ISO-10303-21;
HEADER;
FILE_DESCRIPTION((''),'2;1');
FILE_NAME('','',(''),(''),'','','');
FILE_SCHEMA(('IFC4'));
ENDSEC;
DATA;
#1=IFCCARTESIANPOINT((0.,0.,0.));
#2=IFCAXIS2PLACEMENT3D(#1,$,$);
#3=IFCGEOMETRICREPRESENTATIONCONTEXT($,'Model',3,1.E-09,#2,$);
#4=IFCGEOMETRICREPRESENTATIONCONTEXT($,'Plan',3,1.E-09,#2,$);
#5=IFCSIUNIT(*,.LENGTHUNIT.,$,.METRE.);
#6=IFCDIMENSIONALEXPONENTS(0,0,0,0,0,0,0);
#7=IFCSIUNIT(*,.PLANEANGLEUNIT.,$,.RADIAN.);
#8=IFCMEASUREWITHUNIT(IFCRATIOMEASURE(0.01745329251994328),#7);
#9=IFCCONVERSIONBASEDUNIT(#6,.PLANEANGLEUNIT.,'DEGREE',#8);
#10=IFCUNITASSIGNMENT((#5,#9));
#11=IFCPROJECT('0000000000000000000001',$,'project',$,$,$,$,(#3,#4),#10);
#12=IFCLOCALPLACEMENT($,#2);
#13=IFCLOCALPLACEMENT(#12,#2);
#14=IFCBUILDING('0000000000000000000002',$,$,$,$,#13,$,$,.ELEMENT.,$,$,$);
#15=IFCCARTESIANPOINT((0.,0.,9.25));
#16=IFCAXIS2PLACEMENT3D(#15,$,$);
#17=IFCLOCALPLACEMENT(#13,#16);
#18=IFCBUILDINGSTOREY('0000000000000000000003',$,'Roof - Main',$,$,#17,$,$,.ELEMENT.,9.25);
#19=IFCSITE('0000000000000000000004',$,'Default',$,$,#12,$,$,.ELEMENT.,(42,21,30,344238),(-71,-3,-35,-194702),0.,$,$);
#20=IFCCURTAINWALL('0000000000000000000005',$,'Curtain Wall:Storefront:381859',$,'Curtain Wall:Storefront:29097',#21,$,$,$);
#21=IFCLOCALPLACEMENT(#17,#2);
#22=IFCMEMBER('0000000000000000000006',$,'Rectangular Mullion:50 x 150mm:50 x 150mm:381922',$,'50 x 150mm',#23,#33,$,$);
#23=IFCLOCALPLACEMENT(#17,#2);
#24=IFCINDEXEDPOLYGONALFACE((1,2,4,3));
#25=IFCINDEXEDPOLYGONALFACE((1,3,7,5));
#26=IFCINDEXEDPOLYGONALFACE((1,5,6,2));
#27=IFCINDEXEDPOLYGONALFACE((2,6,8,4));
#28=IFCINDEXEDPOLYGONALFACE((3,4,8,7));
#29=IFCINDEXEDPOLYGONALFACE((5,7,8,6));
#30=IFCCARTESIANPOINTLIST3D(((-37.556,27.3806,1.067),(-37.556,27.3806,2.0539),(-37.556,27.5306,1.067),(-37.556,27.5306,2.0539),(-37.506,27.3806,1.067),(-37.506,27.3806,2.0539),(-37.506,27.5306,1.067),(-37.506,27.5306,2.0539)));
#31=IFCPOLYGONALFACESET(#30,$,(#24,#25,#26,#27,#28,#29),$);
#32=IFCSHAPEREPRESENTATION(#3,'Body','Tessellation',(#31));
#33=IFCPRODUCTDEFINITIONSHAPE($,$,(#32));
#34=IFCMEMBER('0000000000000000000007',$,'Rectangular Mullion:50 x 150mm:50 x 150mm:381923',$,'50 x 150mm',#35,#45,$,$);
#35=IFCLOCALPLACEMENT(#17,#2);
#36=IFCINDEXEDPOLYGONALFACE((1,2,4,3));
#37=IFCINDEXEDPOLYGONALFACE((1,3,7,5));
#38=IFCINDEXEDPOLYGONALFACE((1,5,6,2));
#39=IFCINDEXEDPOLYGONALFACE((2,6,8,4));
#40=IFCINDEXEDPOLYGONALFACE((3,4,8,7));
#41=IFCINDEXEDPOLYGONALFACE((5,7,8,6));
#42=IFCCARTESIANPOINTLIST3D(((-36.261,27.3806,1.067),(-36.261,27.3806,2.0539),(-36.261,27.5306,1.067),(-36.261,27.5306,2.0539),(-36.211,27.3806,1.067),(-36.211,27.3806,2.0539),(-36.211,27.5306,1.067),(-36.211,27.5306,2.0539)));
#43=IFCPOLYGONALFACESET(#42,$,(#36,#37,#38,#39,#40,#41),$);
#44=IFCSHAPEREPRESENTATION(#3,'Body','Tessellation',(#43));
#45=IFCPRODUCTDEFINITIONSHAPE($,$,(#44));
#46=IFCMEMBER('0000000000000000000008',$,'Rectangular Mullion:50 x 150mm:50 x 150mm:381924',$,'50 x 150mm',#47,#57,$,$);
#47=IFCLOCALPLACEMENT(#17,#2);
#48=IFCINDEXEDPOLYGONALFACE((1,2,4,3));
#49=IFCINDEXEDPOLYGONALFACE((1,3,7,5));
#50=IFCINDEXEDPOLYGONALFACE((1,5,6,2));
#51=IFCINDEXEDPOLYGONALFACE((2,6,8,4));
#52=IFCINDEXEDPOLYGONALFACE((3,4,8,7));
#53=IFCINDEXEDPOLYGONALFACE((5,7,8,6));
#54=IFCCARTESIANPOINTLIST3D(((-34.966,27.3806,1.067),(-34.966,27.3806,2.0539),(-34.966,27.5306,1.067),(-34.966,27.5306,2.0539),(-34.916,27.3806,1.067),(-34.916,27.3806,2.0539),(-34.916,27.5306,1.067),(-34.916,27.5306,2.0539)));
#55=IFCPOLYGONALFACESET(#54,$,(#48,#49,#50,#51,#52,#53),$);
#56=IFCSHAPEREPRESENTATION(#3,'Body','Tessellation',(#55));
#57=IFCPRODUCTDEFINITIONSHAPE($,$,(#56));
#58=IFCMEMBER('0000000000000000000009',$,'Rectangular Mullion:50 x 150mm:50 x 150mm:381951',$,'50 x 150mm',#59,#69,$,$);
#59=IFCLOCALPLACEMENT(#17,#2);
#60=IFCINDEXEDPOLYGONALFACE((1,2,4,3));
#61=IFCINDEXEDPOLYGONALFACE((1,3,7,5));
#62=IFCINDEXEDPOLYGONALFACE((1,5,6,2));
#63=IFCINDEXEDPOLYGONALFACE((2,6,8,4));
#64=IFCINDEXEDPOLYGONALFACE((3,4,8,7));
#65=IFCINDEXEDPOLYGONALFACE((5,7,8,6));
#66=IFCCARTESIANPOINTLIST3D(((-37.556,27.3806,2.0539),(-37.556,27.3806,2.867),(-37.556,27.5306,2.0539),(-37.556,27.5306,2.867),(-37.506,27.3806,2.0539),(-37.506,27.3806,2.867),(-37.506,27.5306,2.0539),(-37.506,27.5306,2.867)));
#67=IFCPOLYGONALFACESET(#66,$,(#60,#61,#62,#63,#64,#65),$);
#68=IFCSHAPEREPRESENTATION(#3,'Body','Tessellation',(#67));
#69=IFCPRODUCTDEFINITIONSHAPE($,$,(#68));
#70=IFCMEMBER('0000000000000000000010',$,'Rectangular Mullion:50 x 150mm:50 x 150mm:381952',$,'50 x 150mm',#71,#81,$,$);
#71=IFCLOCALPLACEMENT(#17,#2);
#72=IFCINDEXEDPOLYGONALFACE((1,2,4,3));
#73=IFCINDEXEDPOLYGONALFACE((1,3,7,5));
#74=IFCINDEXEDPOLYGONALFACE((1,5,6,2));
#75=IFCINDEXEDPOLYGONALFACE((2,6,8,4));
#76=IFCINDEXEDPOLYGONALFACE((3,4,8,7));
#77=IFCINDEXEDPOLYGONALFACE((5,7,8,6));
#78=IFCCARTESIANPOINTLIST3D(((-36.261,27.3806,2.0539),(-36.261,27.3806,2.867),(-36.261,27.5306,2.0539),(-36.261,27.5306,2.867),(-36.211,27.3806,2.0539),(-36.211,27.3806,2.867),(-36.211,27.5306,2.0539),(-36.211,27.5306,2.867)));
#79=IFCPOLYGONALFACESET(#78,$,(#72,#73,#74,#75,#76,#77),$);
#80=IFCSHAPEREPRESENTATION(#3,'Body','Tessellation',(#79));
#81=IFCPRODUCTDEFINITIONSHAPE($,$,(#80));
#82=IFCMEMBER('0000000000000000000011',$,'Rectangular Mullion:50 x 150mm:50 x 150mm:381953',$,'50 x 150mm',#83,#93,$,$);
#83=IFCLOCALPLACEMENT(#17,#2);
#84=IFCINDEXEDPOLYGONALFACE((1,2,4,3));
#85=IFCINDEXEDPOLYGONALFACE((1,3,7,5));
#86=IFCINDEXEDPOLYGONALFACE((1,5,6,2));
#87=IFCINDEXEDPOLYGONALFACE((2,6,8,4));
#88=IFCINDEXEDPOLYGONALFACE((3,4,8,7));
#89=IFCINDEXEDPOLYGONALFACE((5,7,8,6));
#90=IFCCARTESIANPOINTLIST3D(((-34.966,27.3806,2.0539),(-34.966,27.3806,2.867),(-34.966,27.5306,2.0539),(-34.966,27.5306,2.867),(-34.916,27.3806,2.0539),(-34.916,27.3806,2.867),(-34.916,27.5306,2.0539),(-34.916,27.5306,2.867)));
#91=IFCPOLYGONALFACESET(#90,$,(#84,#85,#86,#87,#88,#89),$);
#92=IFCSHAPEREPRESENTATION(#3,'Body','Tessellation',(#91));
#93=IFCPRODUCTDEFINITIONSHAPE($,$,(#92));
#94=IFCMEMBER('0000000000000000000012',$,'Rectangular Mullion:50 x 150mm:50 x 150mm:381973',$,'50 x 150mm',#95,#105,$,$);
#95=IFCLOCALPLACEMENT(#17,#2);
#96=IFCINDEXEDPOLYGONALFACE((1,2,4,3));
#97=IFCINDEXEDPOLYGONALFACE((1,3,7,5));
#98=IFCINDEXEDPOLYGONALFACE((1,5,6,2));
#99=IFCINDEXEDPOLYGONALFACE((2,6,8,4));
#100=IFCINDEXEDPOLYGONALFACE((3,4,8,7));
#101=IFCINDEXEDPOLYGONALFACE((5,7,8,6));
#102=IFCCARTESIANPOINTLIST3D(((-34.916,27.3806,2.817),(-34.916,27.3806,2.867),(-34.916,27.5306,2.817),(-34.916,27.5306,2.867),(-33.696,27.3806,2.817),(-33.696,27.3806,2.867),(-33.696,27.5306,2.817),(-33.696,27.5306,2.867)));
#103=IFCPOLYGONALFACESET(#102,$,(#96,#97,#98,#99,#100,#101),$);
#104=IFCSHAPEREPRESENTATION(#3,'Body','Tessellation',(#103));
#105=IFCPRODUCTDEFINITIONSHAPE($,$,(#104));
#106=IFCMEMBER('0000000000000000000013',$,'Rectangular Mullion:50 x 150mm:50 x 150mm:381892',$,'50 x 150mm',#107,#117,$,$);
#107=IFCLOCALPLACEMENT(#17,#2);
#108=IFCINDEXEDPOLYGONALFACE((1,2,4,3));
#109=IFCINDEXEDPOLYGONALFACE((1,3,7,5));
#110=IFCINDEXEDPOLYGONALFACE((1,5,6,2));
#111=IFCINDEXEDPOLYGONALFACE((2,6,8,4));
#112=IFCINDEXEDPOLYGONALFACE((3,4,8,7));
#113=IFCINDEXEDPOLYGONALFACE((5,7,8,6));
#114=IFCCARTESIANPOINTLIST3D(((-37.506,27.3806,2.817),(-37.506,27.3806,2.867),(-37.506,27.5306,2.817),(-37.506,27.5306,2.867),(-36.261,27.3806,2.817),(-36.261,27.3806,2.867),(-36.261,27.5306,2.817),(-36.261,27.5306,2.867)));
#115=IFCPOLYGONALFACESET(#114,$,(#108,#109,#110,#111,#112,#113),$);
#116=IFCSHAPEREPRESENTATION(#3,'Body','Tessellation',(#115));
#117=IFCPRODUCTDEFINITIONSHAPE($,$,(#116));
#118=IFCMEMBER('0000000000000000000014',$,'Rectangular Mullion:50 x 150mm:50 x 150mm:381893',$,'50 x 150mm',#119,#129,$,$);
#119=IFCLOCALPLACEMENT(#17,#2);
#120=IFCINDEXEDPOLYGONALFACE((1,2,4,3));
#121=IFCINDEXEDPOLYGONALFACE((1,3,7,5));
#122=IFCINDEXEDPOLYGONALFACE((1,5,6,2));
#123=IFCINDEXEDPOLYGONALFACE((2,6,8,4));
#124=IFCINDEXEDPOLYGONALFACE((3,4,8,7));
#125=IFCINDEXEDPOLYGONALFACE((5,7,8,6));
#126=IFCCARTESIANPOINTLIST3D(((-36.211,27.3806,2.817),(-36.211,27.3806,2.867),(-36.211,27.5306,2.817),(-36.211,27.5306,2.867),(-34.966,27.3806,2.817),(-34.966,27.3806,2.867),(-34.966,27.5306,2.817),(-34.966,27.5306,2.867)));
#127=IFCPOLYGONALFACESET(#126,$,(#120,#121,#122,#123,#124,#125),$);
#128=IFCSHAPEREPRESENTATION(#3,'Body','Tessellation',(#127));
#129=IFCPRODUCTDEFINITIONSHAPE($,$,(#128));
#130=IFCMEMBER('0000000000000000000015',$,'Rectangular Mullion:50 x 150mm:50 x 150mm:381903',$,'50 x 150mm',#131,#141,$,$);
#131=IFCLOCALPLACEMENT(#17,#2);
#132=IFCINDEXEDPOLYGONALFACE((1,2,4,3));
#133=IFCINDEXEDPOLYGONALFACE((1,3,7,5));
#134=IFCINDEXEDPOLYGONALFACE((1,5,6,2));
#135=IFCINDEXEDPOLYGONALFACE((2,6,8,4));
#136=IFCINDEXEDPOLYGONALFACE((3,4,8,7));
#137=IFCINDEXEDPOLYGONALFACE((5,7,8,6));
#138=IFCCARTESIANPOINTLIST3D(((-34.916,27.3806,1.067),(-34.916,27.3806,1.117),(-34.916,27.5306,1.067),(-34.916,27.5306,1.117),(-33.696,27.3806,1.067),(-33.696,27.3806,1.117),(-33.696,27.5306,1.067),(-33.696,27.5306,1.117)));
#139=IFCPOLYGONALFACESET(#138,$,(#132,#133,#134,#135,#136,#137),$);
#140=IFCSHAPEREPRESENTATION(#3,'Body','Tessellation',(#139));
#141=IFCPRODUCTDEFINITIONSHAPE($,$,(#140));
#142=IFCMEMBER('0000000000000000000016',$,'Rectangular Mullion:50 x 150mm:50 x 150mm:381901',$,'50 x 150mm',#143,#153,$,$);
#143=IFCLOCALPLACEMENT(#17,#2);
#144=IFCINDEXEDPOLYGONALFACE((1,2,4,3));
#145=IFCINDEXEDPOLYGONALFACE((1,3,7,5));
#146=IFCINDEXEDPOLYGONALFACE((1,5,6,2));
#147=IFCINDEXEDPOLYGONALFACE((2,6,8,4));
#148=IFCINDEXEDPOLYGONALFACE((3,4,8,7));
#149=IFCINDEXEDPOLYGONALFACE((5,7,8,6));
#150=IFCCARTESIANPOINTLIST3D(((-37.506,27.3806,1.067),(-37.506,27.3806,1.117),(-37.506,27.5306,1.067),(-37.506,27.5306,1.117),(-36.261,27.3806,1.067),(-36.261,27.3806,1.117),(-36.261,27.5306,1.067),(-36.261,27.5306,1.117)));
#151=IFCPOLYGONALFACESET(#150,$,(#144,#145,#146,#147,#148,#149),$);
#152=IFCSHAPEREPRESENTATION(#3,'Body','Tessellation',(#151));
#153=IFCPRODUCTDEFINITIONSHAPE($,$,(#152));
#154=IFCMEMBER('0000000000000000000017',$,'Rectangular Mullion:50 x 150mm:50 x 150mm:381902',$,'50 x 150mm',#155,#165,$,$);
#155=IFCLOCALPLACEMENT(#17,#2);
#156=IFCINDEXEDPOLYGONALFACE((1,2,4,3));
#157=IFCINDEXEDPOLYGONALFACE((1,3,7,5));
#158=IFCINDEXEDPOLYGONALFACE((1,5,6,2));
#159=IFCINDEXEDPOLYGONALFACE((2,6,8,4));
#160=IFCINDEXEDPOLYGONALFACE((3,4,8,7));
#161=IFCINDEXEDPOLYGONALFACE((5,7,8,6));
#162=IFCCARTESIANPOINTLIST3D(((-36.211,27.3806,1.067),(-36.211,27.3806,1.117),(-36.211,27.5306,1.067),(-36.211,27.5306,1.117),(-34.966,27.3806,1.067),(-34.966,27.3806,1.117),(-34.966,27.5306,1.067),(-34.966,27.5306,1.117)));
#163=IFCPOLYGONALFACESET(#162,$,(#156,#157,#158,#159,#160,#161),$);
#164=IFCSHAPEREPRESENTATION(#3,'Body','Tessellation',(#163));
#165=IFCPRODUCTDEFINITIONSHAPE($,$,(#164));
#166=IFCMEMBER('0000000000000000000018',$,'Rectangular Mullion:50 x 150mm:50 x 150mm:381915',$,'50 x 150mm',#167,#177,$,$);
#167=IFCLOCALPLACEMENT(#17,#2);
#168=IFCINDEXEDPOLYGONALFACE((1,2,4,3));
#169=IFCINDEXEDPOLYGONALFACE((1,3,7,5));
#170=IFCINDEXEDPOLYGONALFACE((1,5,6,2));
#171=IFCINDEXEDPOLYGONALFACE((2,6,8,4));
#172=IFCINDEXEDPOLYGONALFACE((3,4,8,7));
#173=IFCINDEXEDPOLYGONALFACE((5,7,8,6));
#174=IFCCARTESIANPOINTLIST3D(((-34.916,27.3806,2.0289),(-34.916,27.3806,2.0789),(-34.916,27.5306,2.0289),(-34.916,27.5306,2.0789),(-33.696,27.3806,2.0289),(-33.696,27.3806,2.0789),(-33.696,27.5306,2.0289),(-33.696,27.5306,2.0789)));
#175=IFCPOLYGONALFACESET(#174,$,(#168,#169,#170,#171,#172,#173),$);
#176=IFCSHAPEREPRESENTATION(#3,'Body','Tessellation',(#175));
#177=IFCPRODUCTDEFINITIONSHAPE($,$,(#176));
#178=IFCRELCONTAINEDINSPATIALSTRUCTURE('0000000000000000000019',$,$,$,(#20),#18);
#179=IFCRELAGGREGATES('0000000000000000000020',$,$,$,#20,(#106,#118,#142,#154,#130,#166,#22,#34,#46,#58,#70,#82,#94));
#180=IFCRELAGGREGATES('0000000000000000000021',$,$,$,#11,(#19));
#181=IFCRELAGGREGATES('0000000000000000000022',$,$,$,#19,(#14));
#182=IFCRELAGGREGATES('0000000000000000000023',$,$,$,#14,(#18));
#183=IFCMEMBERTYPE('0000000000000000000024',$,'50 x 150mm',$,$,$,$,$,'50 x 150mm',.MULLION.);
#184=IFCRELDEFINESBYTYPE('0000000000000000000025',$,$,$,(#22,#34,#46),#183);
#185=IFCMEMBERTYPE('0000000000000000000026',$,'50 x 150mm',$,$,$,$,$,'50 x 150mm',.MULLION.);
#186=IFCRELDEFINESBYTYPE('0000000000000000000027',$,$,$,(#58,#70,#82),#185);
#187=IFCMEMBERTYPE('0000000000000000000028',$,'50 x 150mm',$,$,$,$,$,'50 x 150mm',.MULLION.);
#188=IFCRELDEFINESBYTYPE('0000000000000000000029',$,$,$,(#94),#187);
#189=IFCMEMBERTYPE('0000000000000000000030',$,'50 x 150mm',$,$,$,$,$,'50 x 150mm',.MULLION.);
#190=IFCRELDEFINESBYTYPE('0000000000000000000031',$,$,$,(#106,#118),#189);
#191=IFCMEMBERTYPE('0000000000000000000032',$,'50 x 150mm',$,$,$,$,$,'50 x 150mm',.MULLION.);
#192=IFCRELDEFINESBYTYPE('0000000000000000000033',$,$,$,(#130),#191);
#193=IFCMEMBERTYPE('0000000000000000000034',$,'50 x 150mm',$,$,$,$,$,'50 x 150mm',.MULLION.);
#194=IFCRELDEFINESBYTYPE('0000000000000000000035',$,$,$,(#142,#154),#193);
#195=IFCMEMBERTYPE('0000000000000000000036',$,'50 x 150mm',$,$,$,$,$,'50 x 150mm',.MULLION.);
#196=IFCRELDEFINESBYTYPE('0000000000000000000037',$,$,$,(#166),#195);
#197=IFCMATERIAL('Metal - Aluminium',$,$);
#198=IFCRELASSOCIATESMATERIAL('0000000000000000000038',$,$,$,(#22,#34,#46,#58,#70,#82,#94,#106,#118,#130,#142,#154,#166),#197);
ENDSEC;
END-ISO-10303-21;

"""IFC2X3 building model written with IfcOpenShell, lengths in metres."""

from ifc_helpers import new_model, entity, si_unit, converted_unit, frame, origin, origin_2d_with_axis, place, context, project, spatial, rectangle, extrude, source, transform, mapped, material, type_object, type_shapes, element, aggregate, save


model = new_model("IFC2X3")

# Units and contexts
model_context = context("Model", 3, precision=1e-09, world=origin())
plan_context = context("Plan", 3, precision=1e-09, world=origin())
ifc_project = project(units=[si_unit("LENGTHUNIT", "METRE"), converted_unit("PLANEANGLEUNIT", "DEGREE", entity("IfcRatioMeasure", 0.01745329251994328), si_unit("PLANEANGLEUNIT", "RADIAN"), dimensions=[0, 0, 0, 0, 0, 0, 0])], contexts=[model_context, plan_context])

# Site, building, storey
site_placement = place(None, origin())
site = spatial("IfcSite", under=ifc_project, at=site_placement, Name="Default", CompositionType="ELEMENT", RefLatitude=(42, 21, 30, 344238), RefLongitude=(-71, -3, -35, -194702), RefElevation=0.0)
building_placement = place(site_placement, origin())
building = spatial("IfcBuilding", under=site, at=building_placement, CompositionType="ELEMENT")
storey_placement = place(building_placement, frame((0.0, 0.0, 9.25)))
storey = spatial("IfcBuildingStorey", under=building, at=storey_placement, Name="Roof - Main", CompositionType="ELEMENT", Elevation=9.25)

# Curtain wall, members
curtain_wall_placement = place(storey_placement, origin())
curtain_wall = element("IfcCurtainWall", 1, at=curtain_wall_placement, inside=storey, Name="Curtain Wall:Storefront:381859", ObjectType="Curtain Wall:Storefront:29097")
ifc_material_1 = material(Name="Metal - Aluminium")
member_type_1 = type_object("IfcMemberType", Name="50 x 150mm", ElementType="50 x 150mm", PredefinedType="MULLION")
shared_shape_1 = source(origin(), model_context, "Body", "SweptSolid", [
    extrude(rectangle(XDim=0.05, YDim=0.15, at=origin_2d_with_axis()), frame((0.0, 0.0, -0.9869), z_axis=(0.0, 0.0, 1.0), x_axis=(-1.0, 0.0, 0.0)), (0.0, 0.0, 1.0), 0.9869),
])
type_shapes(member_type_1, [shared_shape_1])
member_1_placement = place(storey_placement, frame((-37.531, 27.4556, 1.067), z_axis=(0.0, 0.0, -1.0), x_axis=(1.0, 0.0, 0.0)))
member_1 = element("IfcMember", 2, at=member_1_placement, type_object=member_type_1, material=ifc_material_1, Name="Rectangular Mullion:50 x 150mm:50 x 150mm:381922", ObjectType="50 x 150mm", context=model_context, shape_type="MappedRepresentation", body=[
    mapped(shared_shape_1, transform((0.0, 0.0, 0.0), scale=1.0)),
])
member_2_placement = place(storey_placement, frame((-36.236, 27.4556, 1.067), z_axis=(0.0, 0.0, -1.0), x_axis=(1.0, 0.0, 0.0)))
member_2 = element("IfcMember", 3, at=member_2_placement, type_object=member_type_1, material=ifc_material_1, Name="Rectangular Mullion:50 x 150mm:50 x 150mm:381923", ObjectType="50 x 150mm", context=model_context, shape_type="MappedRepresentation", body=[
    mapped(shared_shape_1, transform((0.0, 0.0, 0.0), scale=1.0)),
])
member_3_placement = place(storey_placement, frame((-34.941, 27.4556, 1.067), z_axis=(0.0, 0.0, -1.0), x_axis=(1.0, 0.0, 0.0)))
member_3 = element("IfcMember", 4, at=member_3_placement, type_object=member_type_1, material=ifc_material_1, Name="Rectangular Mullion:50 x 150mm:50 x 150mm:381924", ObjectType="50 x 150mm", context=model_context, shape_type="MappedRepresentation", body=[
    mapped(shared_shape_1, transform((0.0, 0.0, 0.0), scale=1.0)),
])
member_type_2 = type_object("IfcMemberType", Name="50 x 150mm", ElementType="50 x 150mm", PredefinedType="MULLION")
shared_shape_2 = source(origin(), model_context, "Body", "SweptSolid", [
    extrude(rectangle(XDim=0.05, YDim=0.15, at=origin_2d_with_axis()), frame((0.0, 0.0, -0.8131), z_axis=(0.0, 0.0, 1.0), x_axis=(-1.0, 0.0, 0.0)), (0.0, 0.0, 1.0), 0.8131),
])
type_shapes(member_type_2, [shared_shape_2])
member_4_placement = place(storey_placement, frame((-37.531, 27.4556, 2.0539), z_axis=(0.0, 0.0, -1.0), x_axis=(1.0, 0.0, 0.0)))
member_4 = element("IfcMember", 5, at=member_4_placement, type_object=member_type_2, material=ifc_material_1, Name="Rectangular Mullion:50 x 150mm:50 x 150mm:381951", ObjectType="50 x 150mm", context=model_context, shape_type="MappedRepresentation", body=[
    mapped(shared_shape_2, transform((0.0, 0.0, 0.0), scale=1.0)),
])
member_5_placement = place(storey_placement, frame((-36.236, 27.4556, 2.0539), z_axis=(0.0, 0.0, -1.0), x_axis=(1.0, 0.0, 0.0)))
member_5 = element("IfcMember", 6, at=member_5_placement, type_object=member_type_2, material=ifc_material_1, Name="Rectangular Mullion:50 x 150mm:50 x 150mm:381952", ObjectType="50 x 150mm", context=model_context, shape_type="MappedRepresentation", body=[
    mapped(shared_shape_2, transform((0.0, 0.0, 0.0), scale=1.0)),
])
member_6_placement = place(storey_placement, frame((-34.941, 27.4556, 2.0539), z_axis=(0.0, 0.0, -1.0), x_axis=(1.0, 0.0, 0.0)))
member_6 = element("IfcMember", 7, at=member_6_placement, type_object=member_type_2, material=ifc_material_1, Name="Rectangular Mullion:50 x 150mm:50 x 150mm:381953", ObjectType="50 x 150mm", context=model_context, shape_type="MappedRepresentation", body=[
    mapped(shared_shape_2, transform((0.0, 0.0, 0.0), scale=1.0)),
])
member_type_3 = type_object("IfcMemberType", Name="50 x 150mm", ElementType="50 x 150mm", PredefinedType="MULLION")
shared_shape_3 = source(origin(), model_context, "Body", "SweptSolid", [
    extrude(rectangle(XDim=0.05, YDim=0.15, at=origin_2d_with_axis()), frame((-0.025, 0.0, -1.22), z_axis=(0.0, 0.0, 1.0), x_axis=(-1.0, 0.0, 0.0)), (0.0, 0.0, 1.0), 1.22),
])
type_shapes(member_type_3, [shared_shape_3])
member_7_placement = place(storey_placement, frame((-33.696, 27.4556, 2.867), z_axis=(1.0, 0.0, 0.0), x_axis=(0.0, 0.0, 1.0)))
member_7 = element("IfcMember", 8, at=member_7_placement, type_object=member_type_3, material=ifc_material_1, Name="Rectangular Mullion:50 x 150mm:50 x 150mm:381973", ObjectType="50 x 150mm", context=model_context, shape_type="MappedRepresentation", body=[
    mapped(shared_shape_3, transform((0.0, 0.0, 0.0), scale=1.0)),
])
member_type_4 = type_object("IfcMemberType", Name="50 x 150mm", ElementType="50 x 150mm", PredefinedType="MULLION")
shared_shape_4 = source(origin(), model_context, "Body", "SweptSolid", [
    extrude(rectangle(XDim=0.05, YDim=0.15, at=origin_2d_with_axis()), frame((-0.025, 0.0, -1.245), z_axis=(0.0, 0.0, 1.0), x_axis=(-1.0, 0.0, 0.0)), (0.0, 0.0, 1.0), 1.245),
])
type_shapes(member_type_4, [shared_shape_4])
member_8_placement = place(storey_placement, frame((-36.261, 27.4556, 2.867), z_axis=(1.0, 0.0, 0.0), x_axis=(0.0, 0.0, 1.0)))
member_8 = element("IfcMember", 9, at=member_8_placement, type_object=member_type_4, material=ifc_material_1, Name="Rectangular Mullion:50 x 150mm:50 x 150mm:381892", ObjectType="50 x 150mm", context=model_context, shape_type="MappedRepresentation", body=[
    mapped(shared_shape_4, transform((0.0, 0.0, 0.0), scale=1.0)),
])
member_9_placement = place(storey_placement, frame((-34.966, 27.4556, 2.867), z_axis=(1.0, 0.0, 0.0), x_axis=(0.0, 0.0, 1.0)))
member_9 = element("IfcMember", 10, at=member_9_placement, type_object=member_type_4, material=ifc_material_1, Name="Rectangular Mullion:50 x 150mm:50 x 150mm:381893", ObjectType="50 x 150mm", context=model_context, shape_type="MappedRepresentation", body=[
    mapped(shared_shape_4, transform((0.0, 0.0, 0.0), scale=1.0)),
])
member_type_5 = type_object("IfcMemberType", Name="50 x 150mm", ElementType="50 x 150mm", PredefinedType="MULLION")
shared_shape_5 = source(origin(), model_context, "Body", "SweptSolid", [
    extrude(rectangle(XDim=0.05, YDim=0.15, at=origin_2d_with_axis()), frame((-0.025, 0.0, -1.22), z_axis=(0.0, 0.0, 1.0), x_axis=(-1.0, 0.0, 0.0)), (0.0, 0.0, 1.0), 1.22),
])
type_shapes(member_type_5, [shared_shape_5])
member_10_placement = place(storey_placement, frame((-34.916, 27.4556, 1.067), z_axis=(-1.0, 0.0, 0.0), x_axis=(0.0, 0.0, -1.0)))
member_10 = element("IfcMember", 11, at=member_10_placement, type_object=member_type_5, material=ifc_material_1, Name="Rectangular Mullion:50 x 150mm:50 x 150mm:381903", ObjectType="50 x 150mm", context=model_context, shape_type="MappedRepresentation", body=[
    mapped(shared_shape_5, transform((0.0, 0.0, 0.0), scale=1.0)),
])
member_type_6 = type_object("IfcMemberType", Name="50 x 150mm", ElementType="50 x 150mm", PredefinedType="MULLION")
shared_shape_6 = source(origin(), model_context, "Body", "SweptSolid", [
    extrude(rectangle(XDim=0.05, YDim=0.15, at=origin_2d_with_axis()), frame((-0.025, 0.0, -1.245), z_axis=(0.0, 0.0, 1.0), x_axis=(-1.0, 0.0, 0.0)), (0.0, 0.0, 1.0), 1.245),
])
type_shapes(member_type_6, [shared_shape_6])
member_11_placement = place(storey_placement, frame((-37.506, 27.4556, 1.067), z_axis=(-1.0, 0.0, 0.0), x_axis=(0.0, 0.0, -1.0)))
member_11 = element("IfcMember", 12, at=member_11_placement, type_object=member_type_6, material=ifc_material_1, Name="Rectangular Mullion:50 x 150mm:50 x 150mm:381901", ObjectType="50 x 150mm", context=model_context, shape_type="MappedRepresentation", body=[
    mapped(shared_shape_6, transform((0.0, 0.0, 0.0), scale=1.0)),
])
member_12_placement = place(storey_placement, frame((-36.211, 27.4556, 1.067), z_axis=(-1.0, 0.0, 0.0), x_axis=(0.0, 0.0, -1.0)))
member_12 = element("IfcMember", 13, at=member_12_placement, type_object=member_type_6, material=ifc_material_1, Name="Rectangular Mullion:50 x 150mm:50 x 150mm:381902", ObjectType="50 x 150mm", context=model_context, shape_type="MappedRepresentation", body=[
    mapped(shared_shape_6, transform((0.0, 0.0, 0.0), scale=1.0)),
])
member_type_7 = type_object("IfcMemberType", Name="50 x 150mm", ElementType="50 x 150mm", PredefinedType="MULLION")
shared_shape_7 = source(origin(), model_context, "Body", "SweptSolid", [
    extrude(rectangle(XDim=0.05, YDim=0.15, at=origin_2d_with_axis()), frame((0.0, 0.0, -1.22), z_axis=(0.0, 0.0, 1.0), x_axis=(-1.0, 0.0, 0.0)), (0.0, 0.0, 1.0), 1.22),
])
type_shapes(member_type_7, [shared_shape_7])
member_13_placement = place(storey_placement, frame((-33.696, 27.4556, 2.0539), z_axis=(1.0, 0.0, 0.0), x_axis=(0.0, 0.0, 1.0)))
member_13 = element("IfcMember", 14, at=member_13_placement, type_object=member_type_7, material=ifc_material_1, Name="Rectangular Mullion:50 x 150mm:50 x 150mm:381915", ObjectType="50 x 150mm", context=model_context, shape_type="MappedRepresentation", body=[
    mapped(shared_shape_7, transform((0.0, 0.0, 0.0), scale=1.0)),
])
aggregate(curtain_wall, [member_8, member_9, member_11, member_12, member_10, member_13, member_1, member_2, member_3, member_4, member_5, member_6, member_7])

save(model, "model.ifc")
